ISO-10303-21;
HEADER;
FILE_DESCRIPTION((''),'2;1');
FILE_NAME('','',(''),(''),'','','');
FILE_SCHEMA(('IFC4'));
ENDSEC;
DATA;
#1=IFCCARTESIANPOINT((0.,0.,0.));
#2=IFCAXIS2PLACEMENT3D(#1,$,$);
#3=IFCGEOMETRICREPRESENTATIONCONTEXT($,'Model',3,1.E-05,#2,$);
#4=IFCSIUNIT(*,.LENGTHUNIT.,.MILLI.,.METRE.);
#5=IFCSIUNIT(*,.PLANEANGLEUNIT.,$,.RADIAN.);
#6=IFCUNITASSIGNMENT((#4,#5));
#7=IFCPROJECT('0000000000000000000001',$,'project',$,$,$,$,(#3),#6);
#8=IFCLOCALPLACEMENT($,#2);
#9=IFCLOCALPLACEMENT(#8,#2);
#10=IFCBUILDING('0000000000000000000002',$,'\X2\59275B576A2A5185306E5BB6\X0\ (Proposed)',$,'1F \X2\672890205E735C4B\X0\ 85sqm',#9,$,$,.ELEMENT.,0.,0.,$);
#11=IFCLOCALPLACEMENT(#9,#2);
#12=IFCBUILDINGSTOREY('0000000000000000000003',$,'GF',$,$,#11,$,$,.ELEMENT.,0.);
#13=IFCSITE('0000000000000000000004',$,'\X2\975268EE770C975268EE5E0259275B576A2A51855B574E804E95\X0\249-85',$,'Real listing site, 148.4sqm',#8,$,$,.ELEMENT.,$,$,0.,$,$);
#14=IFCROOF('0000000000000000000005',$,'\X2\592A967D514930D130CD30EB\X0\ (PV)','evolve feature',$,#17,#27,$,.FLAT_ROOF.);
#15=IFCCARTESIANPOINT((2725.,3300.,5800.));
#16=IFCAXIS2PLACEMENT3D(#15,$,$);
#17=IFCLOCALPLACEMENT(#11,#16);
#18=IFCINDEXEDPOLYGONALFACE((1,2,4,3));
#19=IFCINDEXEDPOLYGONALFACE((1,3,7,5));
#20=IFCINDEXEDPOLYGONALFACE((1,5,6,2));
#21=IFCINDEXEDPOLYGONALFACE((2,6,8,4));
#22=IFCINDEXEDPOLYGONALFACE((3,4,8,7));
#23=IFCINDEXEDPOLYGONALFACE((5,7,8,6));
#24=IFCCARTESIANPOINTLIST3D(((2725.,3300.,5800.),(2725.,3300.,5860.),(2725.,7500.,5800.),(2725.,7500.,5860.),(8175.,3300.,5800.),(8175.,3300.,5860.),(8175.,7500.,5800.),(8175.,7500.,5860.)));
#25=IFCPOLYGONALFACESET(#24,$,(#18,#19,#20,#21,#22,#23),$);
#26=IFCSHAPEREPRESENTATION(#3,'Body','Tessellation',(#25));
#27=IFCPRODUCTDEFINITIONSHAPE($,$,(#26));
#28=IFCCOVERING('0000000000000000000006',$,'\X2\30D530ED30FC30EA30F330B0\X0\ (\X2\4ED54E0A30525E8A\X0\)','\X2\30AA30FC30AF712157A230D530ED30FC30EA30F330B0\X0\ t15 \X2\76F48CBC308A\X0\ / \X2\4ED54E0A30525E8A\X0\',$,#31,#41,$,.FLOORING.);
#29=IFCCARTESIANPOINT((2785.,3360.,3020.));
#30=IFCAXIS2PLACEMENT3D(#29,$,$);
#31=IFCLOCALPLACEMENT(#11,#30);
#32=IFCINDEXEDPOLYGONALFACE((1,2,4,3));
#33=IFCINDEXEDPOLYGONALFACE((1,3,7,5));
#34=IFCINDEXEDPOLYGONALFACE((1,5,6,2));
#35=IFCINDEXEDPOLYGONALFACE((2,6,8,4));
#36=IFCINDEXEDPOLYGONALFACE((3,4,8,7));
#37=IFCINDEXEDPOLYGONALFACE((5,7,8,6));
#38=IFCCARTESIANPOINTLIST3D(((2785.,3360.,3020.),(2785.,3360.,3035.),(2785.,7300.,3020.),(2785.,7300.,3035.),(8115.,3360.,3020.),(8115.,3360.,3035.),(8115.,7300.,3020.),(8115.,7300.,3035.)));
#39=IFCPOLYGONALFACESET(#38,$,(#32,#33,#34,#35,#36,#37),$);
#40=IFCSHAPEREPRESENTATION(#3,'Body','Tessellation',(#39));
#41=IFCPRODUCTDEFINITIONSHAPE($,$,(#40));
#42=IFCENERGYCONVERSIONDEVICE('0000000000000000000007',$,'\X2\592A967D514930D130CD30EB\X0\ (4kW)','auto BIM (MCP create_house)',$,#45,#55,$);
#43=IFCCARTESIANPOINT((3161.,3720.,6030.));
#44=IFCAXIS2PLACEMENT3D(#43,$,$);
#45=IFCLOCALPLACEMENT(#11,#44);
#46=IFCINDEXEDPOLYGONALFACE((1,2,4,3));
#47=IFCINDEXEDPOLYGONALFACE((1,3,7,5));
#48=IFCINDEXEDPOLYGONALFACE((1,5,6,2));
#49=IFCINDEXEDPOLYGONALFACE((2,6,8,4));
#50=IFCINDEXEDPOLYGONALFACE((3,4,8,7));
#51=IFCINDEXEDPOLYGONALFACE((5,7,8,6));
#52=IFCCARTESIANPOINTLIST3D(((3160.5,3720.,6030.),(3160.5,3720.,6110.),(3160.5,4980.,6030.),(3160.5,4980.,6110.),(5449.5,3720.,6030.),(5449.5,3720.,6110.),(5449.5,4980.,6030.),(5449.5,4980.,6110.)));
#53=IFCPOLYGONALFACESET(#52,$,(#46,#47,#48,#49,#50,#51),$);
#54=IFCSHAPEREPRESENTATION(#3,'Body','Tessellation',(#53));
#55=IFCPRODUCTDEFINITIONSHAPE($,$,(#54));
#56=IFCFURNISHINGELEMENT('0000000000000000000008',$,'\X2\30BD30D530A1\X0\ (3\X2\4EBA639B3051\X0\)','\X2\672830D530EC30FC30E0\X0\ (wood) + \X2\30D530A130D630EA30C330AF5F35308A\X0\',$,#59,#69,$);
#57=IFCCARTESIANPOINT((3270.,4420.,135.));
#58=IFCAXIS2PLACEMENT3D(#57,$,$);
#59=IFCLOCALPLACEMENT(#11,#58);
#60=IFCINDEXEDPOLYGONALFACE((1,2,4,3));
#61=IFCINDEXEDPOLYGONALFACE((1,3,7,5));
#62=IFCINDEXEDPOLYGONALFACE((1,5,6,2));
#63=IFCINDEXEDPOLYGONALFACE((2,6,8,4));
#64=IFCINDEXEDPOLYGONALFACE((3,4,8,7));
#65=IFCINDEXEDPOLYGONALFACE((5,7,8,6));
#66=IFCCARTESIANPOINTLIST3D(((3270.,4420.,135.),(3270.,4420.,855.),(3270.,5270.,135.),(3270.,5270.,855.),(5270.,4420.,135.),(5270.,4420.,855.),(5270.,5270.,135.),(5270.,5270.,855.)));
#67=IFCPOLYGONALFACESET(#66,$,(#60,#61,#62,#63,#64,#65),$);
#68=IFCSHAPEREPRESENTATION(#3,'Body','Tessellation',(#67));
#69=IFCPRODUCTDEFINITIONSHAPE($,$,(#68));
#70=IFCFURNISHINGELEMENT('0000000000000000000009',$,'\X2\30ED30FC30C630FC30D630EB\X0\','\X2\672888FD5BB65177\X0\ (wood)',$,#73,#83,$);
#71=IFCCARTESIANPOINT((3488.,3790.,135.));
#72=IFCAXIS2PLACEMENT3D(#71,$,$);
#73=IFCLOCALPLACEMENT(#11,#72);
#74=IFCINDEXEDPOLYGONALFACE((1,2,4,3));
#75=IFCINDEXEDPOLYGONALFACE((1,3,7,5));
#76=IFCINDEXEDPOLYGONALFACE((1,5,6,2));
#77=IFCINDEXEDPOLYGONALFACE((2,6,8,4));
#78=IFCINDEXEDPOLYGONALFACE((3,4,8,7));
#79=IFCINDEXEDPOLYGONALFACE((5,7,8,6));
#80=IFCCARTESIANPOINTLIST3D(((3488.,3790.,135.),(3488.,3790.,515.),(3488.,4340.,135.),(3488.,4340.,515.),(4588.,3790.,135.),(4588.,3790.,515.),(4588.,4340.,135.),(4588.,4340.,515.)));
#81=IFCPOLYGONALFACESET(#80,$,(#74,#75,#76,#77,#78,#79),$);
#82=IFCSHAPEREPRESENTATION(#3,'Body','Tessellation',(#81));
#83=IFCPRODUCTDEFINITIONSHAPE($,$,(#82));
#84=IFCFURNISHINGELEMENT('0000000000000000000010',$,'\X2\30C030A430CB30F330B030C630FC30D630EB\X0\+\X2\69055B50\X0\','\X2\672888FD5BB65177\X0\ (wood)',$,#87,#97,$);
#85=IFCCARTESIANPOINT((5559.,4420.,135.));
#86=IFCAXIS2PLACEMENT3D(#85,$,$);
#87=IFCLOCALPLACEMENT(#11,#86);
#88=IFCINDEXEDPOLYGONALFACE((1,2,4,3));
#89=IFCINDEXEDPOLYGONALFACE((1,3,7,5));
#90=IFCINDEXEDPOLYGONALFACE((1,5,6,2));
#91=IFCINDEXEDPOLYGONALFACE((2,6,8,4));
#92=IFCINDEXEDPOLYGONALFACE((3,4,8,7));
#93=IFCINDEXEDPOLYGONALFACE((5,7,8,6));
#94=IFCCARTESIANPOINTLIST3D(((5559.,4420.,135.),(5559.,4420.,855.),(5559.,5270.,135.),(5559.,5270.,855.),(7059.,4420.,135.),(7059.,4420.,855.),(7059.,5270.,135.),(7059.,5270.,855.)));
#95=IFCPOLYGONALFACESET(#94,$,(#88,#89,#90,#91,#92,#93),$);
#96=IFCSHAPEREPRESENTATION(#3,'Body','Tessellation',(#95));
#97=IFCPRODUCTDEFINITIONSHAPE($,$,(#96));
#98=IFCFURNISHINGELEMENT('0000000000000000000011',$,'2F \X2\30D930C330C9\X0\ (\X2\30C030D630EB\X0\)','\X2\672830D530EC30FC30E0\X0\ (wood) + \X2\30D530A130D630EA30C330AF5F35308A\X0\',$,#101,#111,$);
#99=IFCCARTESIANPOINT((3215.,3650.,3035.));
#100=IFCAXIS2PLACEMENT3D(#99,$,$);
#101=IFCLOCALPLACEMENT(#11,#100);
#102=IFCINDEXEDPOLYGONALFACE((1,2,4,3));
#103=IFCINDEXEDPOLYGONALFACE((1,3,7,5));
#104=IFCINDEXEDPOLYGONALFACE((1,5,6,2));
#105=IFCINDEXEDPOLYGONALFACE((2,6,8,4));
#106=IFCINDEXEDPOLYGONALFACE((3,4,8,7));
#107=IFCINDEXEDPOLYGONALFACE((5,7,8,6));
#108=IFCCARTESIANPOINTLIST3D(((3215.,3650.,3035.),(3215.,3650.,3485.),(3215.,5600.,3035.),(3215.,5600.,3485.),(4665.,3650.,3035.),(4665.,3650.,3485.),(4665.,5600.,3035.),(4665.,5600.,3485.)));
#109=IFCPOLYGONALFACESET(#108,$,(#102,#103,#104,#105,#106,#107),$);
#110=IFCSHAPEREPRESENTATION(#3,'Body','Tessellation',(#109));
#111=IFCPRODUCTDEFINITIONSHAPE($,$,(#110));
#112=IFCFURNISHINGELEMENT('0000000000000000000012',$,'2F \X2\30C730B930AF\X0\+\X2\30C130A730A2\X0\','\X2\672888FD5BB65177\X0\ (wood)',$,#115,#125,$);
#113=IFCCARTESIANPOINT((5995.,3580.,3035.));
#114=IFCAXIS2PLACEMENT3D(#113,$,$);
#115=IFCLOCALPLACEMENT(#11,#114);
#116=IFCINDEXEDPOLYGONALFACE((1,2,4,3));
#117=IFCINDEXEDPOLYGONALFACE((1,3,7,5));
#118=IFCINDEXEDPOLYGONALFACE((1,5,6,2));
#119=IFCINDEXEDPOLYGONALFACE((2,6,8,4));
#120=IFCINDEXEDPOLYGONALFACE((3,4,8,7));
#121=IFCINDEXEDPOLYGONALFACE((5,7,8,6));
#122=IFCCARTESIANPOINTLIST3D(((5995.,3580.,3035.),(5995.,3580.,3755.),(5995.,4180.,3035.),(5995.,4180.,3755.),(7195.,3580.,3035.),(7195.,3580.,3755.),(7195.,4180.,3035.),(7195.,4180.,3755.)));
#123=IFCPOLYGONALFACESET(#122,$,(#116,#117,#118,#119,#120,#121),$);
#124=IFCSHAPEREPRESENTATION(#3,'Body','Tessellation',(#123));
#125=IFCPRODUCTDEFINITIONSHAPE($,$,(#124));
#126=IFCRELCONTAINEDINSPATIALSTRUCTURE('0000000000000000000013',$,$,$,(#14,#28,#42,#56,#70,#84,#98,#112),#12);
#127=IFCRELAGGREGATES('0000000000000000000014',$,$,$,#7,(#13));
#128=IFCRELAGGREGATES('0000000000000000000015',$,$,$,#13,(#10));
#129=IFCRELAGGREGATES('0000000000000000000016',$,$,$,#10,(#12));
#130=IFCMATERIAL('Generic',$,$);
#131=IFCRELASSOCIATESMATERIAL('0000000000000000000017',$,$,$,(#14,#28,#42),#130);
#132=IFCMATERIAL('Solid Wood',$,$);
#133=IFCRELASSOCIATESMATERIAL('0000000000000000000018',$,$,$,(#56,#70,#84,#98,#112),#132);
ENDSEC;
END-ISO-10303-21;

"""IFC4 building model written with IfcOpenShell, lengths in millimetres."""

from ifc_helpers import new_model, si_unit, frame, frame_2d, origin, place, context, project, spatial, rectangle, extrude, material, element, save


model = new_model("IFC4")

# Units and contexts
model_context = context("Model", 3, precision=1e-05, world=origin())
ifc_project = project(units=[si_unit("LENGTHUNIT", "METRE", prefix="MILLI"), si_unit("PLANEANGLEUNIT", "RADIAN")], contexts=[model_context])

# Site, building, storey
site_placement = place(None, origin())
site = spatial("IfcSite", under=ifc_project, at=site_placement, Name="青森県青森市大字横内字亀井249-85", ObjectType="Real listing site, 148.4sqm", CompositionType="ELEMENT", RefElevation=0.0)
building_placement = place(site_placement, origin())
building = spatial("IfcBuilding", under=site, at=building_placement, Name="大字横内の家 (Proposed)", ObjectType="1F 木造平屋 85sqm", CompositionType="ELEMENT", ElevationOfRefHeight=0.0, ElevationOfTerrain=0.0)
storey_placement = place(building_placement, origin())
storey = spatial("IfcBuildingStorey", under=building, at=storey_placement, Name="GF", CompositionType="ELEMENT", Elevation=0.0)

# Shared definitions
ifc_material_1 = material(Name="Solid Wood")

# Shared definitions
ifc_material_2 = material(Name="Generic")

# Roof
roof_placement = place(storey_placement, frame((2725.0, 3300.0, 5800.0)))
element("IfcRoof", 1, at=roof_placement, inside=storey, material=ifc_material_2, Name="太陽光パネル (PV)", Description="evolve feature", PredefinedType="FLAT_ROOF", context=model_context, shape_type="SweptSolid", body=[
    extrude(rectangle(XDim=5450.0, YDim=4200.0, at=frame_2d((2725.0, 2100.0))), frame((2725.0, 3300.0, 5800.0)), (0.0, 0.0, 1.0), 60.0),
])

# Covering
covering_placement = place(storey_placement, frame((2785.0, 3360.0, 3020.0)))
element("IfcCovering", 2, at=covering_placement, inside=storey, material=ifc_material_2, Name="フローリング (仕上げ床)", Description="オーク無垢フローリング t15 直貼り / 仕上げ床", PredefinedType="FLOORING", context=model_context, shape_type="SweptSolid", body=[
    extrude(rectangle(XDim=5330.0, YDim=3940.0, at=frame_2d((2665.0, 1970.0))), frame((2785.0, 3360.0, 3020.0)), (0.0, 0.0, 1.0), 15.0),
])

# Energy conversion device
energy_conversion_device_placement = place(storey_placement, frame((3161.0, 3720.0, 6030.0)))
element("IfcEnergyConversionDevice", 3, at=energy_conversion_device_placement, inside=storey, material=ifc_material_2, Name="太陽光パネル (4kW)", Description="auto BIM (MCP create_house)", context=model_context, shape_type="SweptSolid", body=[
    extrude(rectangle(XDim=2289.0, YDim=1260.0, at=frame_2d((1144.0, 630.0))), frame((3161.0, 3720.0, 6030.0)), (0.0, 0.0, 1.0), 80.0),
])

# Furnishing elements
furnishing_1_placement = place(storey_placement, frame((3270.0, 4420.0, 135.0)))
element("IfcFurnishingElement", 4, at=furnishing_1_placement, inside=storey, material=ifc_material_1, Name="ソファ (3人掛け)", Description="木フレーム (wood) + ファブリック張り", context=model_context, shape_type="SweptSolid", body=[
    extrude(rectangle(XDim=2000.0, YDim=850.0, at=frame_2d((1000.0, 425.0))), frame((3270.0, 4420.0, 135.0)), (0.0, 0.0, 1.0), 720.0),
])
furnishing_2_placement = place(storey_placement, frame((3488.0, 3790.0, 135.0)))
element("IfcFurnishingElement", 5, at=furnishing_2_placement, inside=storey, material=ifc_material_1, Name="ローテーブル", Description="木製家具 (wood)", context=model_context, shape_type="SweptSolid", body=[
    extrude(rectangle(XDim=1100.0, YDim=550.0, at=frame_2d((550.0, 275.0))), frame((3488.0, 3790.0, 135.0)), (0.0, 0.0, 1.0), 380.0),
])
furnishing_3_placement = place(storey_placement, frame((5559.0, 4420.0, 135.0)))
element("IfcFurnishingElement", 6, at=furnishing_3_placement, inside=storey, material=ifc_material_1, Name="ダイニングテーブル+椅子", Description="木製家具 (wood)", context=model_context, shape_type="SweptSolid", body=[
    extrude(rectangle(XDim=1500.0, YDim=850.0, at=frame_2d((750.0, 425.0))), frame((5559.0, 4420.0, 135.0)), (0.0, 0.0, 1.0), 720.0),
])
furnishing_4_placement = place(storey_placement, frame((3215.0, 3650.0, 3035.0)))
element("IfcFurnishingElement", 7, at=furnishing_4_placement, inside=storey, material=ifc_material_1, Name="2F ベッド (ダブル)", Description="木フレーム (wood) + ファブリック張り", context=model_context, shape_type="SweptSolid", body=[
    extrude(rectangle(XDim=1450.0, YDim=1950.0, at=frame_2d((725.0, 975.0))), frame((3215.0, 3650.0, 3035.0)), (0.0, 0.0, 1.0), 450.0),
])
furnishing_5_placement = place(storey_placement, frame((5995.0, 3580.0, 3035.0)))
element("IfcFurnishingElement", 8, at=furnishing_5_placement, inside=storey, material=ifc_material_1, Name="2F デスク+チェア", Description="木製家具 (wood)", context=model_context, shape_type="SweptSolid", body=[
    extrude(rectangle(XDim=1200.0, YDim=600.0, at=frame_2d((600.0, 300.0))), frame((5995.0, 3580.0, 3035.0)), (0.0, 0.0, 1.0), 720.0),
])

save(model, "model.ifc")
